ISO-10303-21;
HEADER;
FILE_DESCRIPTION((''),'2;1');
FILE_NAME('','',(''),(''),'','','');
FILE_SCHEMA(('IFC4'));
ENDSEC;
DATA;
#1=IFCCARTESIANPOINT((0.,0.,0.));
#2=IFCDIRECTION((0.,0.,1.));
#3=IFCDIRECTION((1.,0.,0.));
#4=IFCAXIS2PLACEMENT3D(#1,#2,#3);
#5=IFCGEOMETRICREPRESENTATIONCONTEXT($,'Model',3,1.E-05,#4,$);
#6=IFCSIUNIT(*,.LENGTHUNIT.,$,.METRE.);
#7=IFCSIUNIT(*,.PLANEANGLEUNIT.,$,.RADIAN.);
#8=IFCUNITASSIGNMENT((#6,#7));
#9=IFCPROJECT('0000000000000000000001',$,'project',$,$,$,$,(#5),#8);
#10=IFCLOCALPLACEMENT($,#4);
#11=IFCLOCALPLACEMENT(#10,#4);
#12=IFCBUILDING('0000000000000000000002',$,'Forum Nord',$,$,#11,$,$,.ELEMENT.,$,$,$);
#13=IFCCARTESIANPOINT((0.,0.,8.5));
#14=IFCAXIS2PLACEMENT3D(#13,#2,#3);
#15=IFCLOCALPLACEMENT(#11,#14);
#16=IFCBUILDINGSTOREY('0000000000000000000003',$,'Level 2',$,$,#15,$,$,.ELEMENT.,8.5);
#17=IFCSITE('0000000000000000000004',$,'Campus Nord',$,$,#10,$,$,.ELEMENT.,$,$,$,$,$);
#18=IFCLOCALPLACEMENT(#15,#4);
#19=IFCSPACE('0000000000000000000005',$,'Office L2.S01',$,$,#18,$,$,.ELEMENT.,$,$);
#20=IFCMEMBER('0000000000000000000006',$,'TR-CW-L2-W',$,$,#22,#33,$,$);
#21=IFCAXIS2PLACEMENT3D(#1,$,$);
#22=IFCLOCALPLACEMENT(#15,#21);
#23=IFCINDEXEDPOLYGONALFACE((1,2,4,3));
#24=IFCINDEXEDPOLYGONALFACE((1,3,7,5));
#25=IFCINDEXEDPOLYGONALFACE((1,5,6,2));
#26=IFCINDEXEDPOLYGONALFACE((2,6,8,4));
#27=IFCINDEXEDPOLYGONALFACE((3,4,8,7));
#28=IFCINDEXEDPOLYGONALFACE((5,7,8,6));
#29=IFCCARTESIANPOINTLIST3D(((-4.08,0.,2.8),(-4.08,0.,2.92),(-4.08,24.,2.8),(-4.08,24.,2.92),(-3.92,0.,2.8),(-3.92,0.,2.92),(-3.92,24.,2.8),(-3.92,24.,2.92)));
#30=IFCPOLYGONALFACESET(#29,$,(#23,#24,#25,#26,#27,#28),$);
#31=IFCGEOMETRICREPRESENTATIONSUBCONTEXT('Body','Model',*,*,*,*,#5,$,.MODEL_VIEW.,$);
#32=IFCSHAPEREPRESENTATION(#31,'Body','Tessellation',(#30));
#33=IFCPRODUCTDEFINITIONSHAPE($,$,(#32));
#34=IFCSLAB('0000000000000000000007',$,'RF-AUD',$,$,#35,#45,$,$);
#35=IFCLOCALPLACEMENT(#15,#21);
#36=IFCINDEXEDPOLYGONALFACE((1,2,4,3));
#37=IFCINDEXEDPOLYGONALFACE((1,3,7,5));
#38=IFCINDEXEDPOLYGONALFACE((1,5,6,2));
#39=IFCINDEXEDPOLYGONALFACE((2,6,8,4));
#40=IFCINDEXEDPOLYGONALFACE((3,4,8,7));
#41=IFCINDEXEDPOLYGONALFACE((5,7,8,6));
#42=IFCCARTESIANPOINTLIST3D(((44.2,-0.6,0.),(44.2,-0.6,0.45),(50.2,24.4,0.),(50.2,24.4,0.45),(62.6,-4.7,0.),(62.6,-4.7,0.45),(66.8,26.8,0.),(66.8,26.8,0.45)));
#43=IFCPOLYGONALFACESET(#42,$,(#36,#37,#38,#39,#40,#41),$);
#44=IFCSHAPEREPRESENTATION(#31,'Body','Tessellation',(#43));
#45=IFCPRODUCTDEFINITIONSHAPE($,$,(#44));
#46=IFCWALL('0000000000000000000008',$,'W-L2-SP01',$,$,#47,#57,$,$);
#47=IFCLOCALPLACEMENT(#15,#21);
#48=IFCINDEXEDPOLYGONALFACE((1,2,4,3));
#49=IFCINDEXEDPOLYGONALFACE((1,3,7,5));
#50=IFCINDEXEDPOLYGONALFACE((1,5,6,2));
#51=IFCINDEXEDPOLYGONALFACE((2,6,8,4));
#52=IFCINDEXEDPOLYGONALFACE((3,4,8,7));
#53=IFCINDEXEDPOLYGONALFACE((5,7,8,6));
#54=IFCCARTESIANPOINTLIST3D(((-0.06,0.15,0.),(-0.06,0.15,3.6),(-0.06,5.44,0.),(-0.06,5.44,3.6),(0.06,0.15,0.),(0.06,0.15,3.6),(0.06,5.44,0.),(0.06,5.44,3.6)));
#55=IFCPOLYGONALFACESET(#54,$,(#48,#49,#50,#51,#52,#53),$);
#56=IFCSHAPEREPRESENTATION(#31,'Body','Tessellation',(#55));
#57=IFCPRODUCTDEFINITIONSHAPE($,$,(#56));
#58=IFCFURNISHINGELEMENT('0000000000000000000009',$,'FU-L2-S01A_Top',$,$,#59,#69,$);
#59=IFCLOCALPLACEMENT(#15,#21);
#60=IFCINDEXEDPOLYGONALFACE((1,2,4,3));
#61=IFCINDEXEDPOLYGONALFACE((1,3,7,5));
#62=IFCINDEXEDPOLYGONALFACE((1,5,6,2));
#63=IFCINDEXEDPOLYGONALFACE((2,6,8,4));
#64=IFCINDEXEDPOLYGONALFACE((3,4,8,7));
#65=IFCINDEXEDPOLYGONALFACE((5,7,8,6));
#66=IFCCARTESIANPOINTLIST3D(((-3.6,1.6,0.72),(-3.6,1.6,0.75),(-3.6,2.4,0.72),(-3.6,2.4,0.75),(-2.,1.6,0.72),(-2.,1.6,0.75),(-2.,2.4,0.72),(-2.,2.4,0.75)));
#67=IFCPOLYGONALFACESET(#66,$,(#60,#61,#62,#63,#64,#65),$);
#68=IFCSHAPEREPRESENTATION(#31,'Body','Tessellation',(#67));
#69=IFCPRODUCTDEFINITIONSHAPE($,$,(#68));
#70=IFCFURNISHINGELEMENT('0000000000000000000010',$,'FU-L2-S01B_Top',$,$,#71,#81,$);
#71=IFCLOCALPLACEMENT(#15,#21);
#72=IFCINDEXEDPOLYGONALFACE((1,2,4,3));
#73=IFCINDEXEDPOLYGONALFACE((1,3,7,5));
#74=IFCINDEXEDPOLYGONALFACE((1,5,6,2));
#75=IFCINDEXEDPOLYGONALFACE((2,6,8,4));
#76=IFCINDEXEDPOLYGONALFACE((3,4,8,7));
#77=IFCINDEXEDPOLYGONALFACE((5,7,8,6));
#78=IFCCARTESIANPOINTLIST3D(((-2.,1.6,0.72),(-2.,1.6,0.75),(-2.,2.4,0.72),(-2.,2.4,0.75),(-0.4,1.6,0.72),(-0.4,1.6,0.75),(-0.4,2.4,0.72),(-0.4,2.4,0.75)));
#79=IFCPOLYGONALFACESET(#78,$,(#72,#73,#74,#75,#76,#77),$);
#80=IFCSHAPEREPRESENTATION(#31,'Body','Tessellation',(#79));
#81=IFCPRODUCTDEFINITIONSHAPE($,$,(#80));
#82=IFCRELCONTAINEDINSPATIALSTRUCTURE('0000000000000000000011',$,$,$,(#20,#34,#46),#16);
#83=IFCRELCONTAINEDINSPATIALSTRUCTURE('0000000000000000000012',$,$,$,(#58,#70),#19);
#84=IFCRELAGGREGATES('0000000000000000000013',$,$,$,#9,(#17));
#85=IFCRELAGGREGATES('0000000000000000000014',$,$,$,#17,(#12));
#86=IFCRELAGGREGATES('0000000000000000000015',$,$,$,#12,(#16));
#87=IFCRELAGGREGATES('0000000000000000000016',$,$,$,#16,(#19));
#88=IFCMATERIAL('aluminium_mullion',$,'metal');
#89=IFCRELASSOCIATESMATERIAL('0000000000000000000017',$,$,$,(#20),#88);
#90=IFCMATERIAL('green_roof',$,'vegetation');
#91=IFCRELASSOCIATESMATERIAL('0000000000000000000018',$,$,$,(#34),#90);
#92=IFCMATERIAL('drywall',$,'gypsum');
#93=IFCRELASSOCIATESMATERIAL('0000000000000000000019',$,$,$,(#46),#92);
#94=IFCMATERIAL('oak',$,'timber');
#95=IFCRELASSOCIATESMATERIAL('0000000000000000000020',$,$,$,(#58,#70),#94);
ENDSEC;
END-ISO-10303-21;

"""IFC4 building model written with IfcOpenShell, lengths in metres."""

from ifc_helpers import new_model, si_unit, frame, frame_2d, origin_with_axes, place, context, subcontext, project, spatial, polyline, rectangle, outline, extrude, material, element, save


model = new_model("IFC4")

# Units and contexts
model_context = context("Model", 3, precision=1e-05, world=origin_with_axes())
body_context = subcontext(model_context, "Body", "Model", "MODEL_VIEW")
ifc_project = project(units=[si_unit("LENGTHUNIT", "METRE"), si_unit("PLANEANGLEUNIT", "RADIAN")], contexts=[model_context])

# Site, building, storey
site_placement = place(None, origin_with_axes())
site = spatial("IfcSite", under=ifc_project, at=site_placement, Name="Campus Nord", CompositionType="ELEMENT")
building_placement = place(site_placement, origin_with_axes())
building = spatial("IfcBuilding", under=site, at=building_placement, Name="Forum Nord", CompositionType="ELEMENT")
storey_placement = place(building_placement, frame((0.0, 0.0, 8.5), z_axis=(0.0, 0.0, 1.0), x_axis=(1.0, 0.0, 0.0)))
storey = spatial("IfcBuildingStorey", under=building, at=storey_placement, Name="Level 2", CompositionType="ELEMENT", Elevation=8.5)

# Member
ifc_material_1 = material(Name="aluminium_mullion", Category="metal")
member_placement = place(storey_placement, frame((0.0, 0.0, 2.8), z_axis=(0.0, 0.0, 1.0), x_axis=(1.0, 0.0, 0.0)))
element("IfcMember", 1, at=member_placement, inside=storey, material=ifc_material_1, Name="TR-CW-L2-W", context=body_context, shape_type="SweptSolid", body=[
    extrude(outline(polyline([(-4.08, 24.0), (-4.08, 0.0), (-3.92, 0.0), (-3.92, 24.0), (-4.08, 24.0)])), origin_with_axes(), (0.0, 0.0, 1.0), 0.12),
])

# Slab
ifc_material_2 = material(Name="green_roof", Category="vegetation")
slab_placement = place(storey_placement, frame((0.0, 0.0, 0.45), z_axis=(0.0, 0.0, 1.0), x_axis=(1.0, 0.0, 0.0)))
element("IfcSlab", 2, at=slab_placement, inside=storey, material=ifc_material_2, Name="RF-AUD", context=body_context, shape_type="SweptSolid", body=[
    extrude(outline(polyline([(44.2, -0.6), (62.6, -4.7), (66.8, 26.8), (50.2, 24.4), (44.2, -0.6)])), frame((0.0, 0.0, -0.45), z_axis=(0.0, 0.0, 1.0), x_axis=(1.0, 0.0, 0.0)), (0.0, 0.0, 1.0), 0.45),
])

# Wall
ifc_material_3 = material(Name="drywall", Category="gypsum")
wall_placement = place(storey_placement, frame((0.0, 0.0, 0.0), z_axis=(0.0, 0.0, 1.0), x_axis=(0.0, 1.0, 0.0)))
element("IfcWall", 3, at=wall_placement, inside=storey, material=ifc_material_3, Name="W-L2-SP01", context=body_context, shape_type="SweptSolid", body=[
    extrude(outline(polyline([(0.15, -0.06), (5.44, -0.06), (5.44, 0.06), (0.15, 0.06), (0.15, -0.06)])), origin_with_axes(), (0.0, 0.0, 1.0), 3.6),
])

# Shared definitions
space_placement = place(storey_placement, origin_with_axes())
space = spatial("IfcSpace", under=storey, at=space_placement, Name="Office L2.S01", CompositionType="ELEMENT")

# Furnishing elements
ifc_material_4 = material(Name="oak", Category="timber")
furnishing_1_placement = place(storey_placement, frame((-3.6, 1.0, 0.0), z_axis=(0.0, 0.0, 1.0), x_axis=(1.0, 0.0, 0.0)))
element("IfcFurnishingElement", 4, at=furnishing_1_placement, inside=space, material=ifc_material_4, Name="FU-L2-S01A_Top", context=body_context, shape_type="SweptSolid", body=[
    extrude(rectangle(XDim=1.6, YDim=0.8, at=frame_2d((0.8, 1.0), x_axis=(1.0, 0.0))), frame((0.0, 0.0, 0.72), z_axis=(0.0, 0.0, 1.0), x_axis=(1.0, 0.0, 0.0)), (0.0, 0.0, 1.0), 0.03),
])
furnishing_2_placement = place(storey_placement, frame((-2.0, 1.0, 0.0), z_axis=(0.0, 0.0, 1.0), x_axis=(1.0, 0.0, 0.0)))
element("IfcFurnishingElement", 5, at=furnishing_2_placement, inside=space, material=ifc_material_4, Name="FU-L2-S01B_Top", context=body_context, shape_type="SweptSolid", body=[
    extrude(rectangle(XDim=1.6, YDim=0.8, at=frame_2d((0.8, 1.0), x_axis=(1.0, 0.0))), frame((0.0, 0.0, 0.72), z_axis=(0.0, 0.0, 1.0), x_axis=(1.0, 0.0, 0.0)), (0.0, 0.0, 1.0), 0.03),
])

save(model, "model.ifc")
